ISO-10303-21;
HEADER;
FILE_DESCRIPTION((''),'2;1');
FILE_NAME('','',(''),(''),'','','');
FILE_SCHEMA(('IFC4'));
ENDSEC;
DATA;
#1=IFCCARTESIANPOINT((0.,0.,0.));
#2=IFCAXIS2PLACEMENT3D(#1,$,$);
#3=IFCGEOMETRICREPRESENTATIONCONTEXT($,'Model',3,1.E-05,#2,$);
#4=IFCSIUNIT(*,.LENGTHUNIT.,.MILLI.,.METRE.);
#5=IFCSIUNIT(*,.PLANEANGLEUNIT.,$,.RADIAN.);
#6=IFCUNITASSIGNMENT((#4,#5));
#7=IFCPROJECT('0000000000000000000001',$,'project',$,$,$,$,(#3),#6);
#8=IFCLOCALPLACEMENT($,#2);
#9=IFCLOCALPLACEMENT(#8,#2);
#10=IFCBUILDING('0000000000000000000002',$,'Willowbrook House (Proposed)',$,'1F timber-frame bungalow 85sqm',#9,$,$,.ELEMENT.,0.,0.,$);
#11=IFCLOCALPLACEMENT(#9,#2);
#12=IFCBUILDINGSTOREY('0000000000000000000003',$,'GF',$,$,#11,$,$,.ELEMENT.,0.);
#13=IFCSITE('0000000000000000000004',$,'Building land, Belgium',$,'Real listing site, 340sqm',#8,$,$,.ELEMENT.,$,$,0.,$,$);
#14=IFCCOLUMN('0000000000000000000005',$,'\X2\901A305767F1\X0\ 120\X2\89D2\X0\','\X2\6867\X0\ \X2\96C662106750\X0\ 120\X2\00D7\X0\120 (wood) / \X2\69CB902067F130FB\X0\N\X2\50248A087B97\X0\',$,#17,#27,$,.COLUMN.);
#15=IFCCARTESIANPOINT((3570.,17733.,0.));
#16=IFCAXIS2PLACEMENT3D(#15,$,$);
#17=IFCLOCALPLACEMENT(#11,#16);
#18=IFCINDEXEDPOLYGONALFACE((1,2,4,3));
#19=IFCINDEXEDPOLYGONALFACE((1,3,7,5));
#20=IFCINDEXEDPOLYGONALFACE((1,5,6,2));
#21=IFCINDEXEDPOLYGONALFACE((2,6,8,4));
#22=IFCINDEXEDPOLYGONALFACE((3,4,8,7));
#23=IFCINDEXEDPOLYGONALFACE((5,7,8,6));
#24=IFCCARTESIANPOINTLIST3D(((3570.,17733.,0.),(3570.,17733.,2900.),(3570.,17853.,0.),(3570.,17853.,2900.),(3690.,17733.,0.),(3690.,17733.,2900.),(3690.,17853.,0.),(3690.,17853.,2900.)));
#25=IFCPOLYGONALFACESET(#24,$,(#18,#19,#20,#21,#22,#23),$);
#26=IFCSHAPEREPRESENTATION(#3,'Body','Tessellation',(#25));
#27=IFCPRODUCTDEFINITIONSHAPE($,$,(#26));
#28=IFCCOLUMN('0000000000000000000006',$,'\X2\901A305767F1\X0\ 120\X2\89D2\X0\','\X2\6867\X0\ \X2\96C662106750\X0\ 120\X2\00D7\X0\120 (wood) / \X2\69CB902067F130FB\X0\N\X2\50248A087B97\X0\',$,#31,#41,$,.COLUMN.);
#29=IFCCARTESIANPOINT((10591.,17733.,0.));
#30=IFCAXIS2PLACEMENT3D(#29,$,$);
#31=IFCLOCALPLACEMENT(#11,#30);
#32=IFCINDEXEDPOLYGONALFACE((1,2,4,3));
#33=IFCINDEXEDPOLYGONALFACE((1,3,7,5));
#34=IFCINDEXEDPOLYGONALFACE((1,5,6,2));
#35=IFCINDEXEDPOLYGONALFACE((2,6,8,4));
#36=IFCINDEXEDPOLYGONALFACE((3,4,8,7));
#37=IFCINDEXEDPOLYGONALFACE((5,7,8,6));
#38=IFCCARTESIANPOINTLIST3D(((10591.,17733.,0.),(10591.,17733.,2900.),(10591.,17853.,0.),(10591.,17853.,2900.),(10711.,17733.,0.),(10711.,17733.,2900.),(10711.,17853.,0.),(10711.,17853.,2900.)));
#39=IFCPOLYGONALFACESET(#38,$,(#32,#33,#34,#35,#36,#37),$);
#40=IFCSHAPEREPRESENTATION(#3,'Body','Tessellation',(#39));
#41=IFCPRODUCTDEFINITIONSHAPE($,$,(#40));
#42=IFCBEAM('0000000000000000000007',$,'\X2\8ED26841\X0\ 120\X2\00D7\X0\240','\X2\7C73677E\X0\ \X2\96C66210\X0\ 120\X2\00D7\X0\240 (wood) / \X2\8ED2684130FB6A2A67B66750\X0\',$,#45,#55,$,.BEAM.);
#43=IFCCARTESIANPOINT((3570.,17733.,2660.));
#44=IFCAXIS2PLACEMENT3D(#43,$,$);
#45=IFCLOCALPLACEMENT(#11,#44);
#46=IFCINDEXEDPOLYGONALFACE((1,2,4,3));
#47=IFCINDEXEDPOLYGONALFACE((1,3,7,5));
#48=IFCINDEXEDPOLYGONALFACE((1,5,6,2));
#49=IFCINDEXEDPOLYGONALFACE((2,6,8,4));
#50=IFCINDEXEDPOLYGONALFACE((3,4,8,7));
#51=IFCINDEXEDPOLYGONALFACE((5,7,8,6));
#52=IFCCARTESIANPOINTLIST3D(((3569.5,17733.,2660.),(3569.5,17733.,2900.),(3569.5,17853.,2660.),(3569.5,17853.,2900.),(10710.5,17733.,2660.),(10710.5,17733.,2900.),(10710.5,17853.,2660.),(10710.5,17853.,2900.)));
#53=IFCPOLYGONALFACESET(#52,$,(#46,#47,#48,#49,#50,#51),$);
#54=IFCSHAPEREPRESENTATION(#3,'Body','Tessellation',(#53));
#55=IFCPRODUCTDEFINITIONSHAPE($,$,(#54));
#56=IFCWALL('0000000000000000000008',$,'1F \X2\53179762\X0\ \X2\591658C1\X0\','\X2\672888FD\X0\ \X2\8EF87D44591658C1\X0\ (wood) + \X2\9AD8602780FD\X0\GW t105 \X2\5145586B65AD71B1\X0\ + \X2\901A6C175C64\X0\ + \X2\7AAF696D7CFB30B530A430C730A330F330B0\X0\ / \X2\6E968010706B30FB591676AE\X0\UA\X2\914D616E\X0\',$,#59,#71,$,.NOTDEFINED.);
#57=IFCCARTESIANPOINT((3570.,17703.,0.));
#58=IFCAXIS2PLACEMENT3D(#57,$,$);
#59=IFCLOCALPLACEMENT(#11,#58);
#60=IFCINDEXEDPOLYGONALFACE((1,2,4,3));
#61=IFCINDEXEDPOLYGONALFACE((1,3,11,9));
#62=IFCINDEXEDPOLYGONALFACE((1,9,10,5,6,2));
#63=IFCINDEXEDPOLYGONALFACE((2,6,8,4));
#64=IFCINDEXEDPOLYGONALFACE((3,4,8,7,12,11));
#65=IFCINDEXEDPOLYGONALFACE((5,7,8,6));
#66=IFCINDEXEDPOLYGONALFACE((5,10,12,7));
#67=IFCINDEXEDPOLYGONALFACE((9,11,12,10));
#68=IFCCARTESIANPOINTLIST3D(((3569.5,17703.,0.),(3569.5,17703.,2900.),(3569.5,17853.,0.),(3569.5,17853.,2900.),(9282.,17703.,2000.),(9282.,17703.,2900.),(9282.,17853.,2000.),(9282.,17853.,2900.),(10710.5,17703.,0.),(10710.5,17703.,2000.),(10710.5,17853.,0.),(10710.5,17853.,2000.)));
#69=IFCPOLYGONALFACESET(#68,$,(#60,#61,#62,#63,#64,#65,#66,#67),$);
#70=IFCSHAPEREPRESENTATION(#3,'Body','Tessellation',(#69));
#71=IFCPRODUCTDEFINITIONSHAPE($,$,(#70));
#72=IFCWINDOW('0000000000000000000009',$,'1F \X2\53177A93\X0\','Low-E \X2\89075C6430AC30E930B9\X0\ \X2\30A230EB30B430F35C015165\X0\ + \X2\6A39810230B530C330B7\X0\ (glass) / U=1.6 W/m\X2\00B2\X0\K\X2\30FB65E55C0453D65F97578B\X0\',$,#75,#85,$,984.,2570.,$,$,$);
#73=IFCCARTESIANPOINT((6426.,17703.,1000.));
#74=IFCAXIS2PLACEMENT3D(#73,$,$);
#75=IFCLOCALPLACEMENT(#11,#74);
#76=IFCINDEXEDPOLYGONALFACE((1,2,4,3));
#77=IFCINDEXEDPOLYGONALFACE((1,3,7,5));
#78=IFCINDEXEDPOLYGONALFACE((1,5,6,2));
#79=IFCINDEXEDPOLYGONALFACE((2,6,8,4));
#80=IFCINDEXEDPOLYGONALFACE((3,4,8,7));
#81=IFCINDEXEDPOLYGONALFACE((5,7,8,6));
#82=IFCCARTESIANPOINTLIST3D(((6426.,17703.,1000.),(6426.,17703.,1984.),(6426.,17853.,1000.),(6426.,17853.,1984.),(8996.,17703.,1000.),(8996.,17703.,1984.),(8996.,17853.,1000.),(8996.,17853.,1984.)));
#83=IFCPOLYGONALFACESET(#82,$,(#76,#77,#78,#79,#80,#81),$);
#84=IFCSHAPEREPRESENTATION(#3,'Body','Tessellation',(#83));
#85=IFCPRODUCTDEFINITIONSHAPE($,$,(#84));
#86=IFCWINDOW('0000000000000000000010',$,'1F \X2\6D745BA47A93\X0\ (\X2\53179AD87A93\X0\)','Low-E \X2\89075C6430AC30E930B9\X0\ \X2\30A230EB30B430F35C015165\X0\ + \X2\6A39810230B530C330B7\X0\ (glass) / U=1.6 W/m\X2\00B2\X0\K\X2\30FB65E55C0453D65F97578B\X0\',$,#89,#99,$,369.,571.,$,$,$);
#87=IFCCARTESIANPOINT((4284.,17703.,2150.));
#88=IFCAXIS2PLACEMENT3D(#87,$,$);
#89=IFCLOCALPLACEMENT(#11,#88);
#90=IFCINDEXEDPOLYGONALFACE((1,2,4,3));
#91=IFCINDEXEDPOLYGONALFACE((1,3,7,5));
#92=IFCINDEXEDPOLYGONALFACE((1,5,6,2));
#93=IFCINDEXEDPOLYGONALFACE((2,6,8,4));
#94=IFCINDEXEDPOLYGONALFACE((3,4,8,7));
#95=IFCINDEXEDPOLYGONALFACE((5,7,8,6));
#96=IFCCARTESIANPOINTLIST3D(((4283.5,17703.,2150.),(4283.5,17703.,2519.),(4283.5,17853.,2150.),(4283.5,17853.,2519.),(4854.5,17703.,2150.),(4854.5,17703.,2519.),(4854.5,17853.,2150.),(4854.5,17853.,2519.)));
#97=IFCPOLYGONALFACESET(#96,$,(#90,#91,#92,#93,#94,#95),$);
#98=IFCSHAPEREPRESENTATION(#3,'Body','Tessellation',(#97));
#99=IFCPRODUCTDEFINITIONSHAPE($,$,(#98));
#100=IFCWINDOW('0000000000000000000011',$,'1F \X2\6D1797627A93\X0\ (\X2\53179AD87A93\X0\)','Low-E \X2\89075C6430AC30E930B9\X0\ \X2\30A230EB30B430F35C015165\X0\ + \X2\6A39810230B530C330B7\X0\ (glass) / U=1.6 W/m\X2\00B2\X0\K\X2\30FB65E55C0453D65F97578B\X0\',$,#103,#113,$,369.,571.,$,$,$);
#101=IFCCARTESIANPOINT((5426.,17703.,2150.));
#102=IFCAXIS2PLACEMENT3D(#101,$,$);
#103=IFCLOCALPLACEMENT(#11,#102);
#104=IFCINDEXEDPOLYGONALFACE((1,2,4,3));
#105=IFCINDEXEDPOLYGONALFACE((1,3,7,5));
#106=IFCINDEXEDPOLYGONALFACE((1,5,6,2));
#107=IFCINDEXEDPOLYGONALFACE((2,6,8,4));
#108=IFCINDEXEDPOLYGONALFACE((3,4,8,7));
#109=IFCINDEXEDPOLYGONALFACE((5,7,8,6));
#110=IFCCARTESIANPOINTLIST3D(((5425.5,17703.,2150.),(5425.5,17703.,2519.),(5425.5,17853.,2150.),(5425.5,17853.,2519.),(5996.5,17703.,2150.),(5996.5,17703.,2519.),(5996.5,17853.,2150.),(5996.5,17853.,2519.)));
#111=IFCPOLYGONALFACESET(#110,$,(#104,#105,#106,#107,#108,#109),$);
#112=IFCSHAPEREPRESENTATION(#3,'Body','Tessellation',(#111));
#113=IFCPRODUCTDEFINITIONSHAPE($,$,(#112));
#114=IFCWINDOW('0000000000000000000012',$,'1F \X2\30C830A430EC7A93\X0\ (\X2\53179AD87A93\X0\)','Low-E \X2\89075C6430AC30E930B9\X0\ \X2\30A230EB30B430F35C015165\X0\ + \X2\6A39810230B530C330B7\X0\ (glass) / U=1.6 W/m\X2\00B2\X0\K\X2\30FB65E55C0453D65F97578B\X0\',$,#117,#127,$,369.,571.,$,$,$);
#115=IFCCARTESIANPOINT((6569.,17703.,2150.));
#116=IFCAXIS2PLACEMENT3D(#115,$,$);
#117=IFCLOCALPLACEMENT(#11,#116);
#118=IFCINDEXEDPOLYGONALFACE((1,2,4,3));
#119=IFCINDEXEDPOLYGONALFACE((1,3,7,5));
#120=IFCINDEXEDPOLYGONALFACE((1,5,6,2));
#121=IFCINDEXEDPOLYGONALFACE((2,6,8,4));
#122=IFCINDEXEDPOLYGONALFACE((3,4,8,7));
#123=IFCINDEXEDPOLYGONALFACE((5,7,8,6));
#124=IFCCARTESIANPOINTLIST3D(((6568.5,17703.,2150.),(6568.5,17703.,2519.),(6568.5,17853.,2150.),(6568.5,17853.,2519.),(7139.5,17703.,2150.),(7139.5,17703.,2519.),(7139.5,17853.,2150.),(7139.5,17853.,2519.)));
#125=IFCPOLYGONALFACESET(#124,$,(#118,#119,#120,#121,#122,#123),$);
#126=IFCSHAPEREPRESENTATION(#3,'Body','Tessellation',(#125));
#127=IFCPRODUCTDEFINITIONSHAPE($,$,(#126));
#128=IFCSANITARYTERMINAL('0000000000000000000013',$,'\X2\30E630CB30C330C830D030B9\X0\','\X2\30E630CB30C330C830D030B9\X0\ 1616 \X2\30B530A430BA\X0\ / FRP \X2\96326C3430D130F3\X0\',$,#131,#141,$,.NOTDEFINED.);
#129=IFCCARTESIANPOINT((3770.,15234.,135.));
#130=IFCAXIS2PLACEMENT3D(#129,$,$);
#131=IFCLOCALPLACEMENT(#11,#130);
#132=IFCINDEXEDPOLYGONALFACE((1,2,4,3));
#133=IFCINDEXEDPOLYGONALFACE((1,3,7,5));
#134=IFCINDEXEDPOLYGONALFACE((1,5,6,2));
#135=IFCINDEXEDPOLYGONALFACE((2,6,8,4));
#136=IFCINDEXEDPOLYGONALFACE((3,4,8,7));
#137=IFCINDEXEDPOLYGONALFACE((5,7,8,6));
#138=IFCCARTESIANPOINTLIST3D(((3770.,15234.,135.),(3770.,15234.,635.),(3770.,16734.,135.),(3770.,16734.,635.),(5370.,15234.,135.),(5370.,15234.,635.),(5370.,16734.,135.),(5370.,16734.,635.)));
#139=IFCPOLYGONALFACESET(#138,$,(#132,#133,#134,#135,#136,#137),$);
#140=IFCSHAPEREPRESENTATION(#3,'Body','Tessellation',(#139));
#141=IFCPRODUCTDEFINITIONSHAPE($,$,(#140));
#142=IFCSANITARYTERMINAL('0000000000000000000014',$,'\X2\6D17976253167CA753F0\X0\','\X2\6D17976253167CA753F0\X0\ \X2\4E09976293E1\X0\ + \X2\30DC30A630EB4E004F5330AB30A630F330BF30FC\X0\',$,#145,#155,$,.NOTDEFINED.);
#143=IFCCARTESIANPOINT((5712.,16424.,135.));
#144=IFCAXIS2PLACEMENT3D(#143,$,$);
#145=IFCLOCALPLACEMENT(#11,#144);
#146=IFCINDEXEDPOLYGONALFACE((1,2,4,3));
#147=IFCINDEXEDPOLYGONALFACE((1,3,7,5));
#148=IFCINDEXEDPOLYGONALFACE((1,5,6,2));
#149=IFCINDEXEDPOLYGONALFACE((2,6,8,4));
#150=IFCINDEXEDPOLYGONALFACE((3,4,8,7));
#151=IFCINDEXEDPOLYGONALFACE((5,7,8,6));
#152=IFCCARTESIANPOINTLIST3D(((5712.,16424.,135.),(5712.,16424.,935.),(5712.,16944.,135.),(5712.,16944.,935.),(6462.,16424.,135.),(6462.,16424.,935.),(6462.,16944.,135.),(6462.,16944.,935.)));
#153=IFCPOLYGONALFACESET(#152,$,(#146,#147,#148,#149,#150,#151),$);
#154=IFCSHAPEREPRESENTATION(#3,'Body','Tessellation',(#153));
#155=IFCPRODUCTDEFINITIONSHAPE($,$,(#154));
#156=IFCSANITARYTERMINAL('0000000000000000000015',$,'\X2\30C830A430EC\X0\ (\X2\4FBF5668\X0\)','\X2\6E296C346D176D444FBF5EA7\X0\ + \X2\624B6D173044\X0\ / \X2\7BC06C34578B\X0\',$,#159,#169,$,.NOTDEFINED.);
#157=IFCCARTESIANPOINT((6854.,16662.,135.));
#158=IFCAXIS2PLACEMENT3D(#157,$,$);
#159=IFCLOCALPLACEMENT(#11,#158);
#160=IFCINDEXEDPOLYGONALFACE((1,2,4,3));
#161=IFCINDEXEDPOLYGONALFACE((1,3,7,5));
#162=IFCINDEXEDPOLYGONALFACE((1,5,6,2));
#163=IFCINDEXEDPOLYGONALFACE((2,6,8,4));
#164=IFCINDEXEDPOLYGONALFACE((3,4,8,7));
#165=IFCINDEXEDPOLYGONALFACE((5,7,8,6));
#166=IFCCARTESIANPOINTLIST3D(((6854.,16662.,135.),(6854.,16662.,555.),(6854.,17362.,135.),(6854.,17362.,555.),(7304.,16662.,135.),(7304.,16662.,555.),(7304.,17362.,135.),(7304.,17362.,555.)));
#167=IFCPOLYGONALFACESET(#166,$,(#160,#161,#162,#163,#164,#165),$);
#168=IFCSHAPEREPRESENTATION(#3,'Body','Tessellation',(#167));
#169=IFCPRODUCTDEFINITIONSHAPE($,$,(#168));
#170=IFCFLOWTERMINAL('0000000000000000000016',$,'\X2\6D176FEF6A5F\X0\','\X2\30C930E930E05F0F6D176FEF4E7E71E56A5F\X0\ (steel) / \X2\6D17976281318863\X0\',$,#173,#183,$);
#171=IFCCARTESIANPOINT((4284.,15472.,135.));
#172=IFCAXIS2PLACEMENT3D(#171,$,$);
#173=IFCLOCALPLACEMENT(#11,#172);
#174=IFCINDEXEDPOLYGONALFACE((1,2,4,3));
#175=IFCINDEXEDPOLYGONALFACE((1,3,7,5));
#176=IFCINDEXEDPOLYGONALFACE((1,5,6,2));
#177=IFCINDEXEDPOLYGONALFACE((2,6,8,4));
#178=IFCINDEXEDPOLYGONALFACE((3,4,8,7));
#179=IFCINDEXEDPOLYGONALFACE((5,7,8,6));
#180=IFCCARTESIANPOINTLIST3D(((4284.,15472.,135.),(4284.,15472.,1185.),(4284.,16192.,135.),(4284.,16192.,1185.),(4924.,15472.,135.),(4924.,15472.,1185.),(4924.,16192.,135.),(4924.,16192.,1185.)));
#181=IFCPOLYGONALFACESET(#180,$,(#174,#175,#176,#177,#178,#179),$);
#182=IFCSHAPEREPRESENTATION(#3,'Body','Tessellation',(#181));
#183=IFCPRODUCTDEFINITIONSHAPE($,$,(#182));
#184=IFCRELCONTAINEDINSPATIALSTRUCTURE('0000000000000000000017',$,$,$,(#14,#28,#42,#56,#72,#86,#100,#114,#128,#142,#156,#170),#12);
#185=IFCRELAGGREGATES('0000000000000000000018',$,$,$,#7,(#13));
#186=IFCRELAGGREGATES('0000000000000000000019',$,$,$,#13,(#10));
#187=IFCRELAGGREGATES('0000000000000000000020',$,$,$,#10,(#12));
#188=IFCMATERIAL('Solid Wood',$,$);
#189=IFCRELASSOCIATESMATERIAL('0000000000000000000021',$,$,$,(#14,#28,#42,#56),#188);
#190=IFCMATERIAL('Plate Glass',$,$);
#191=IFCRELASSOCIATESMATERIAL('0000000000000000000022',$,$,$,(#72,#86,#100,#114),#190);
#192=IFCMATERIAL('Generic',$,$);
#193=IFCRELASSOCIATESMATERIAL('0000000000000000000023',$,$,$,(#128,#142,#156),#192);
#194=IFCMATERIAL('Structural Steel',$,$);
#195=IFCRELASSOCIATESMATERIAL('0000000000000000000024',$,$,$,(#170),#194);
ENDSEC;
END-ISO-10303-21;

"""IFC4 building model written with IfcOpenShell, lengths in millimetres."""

from ifc_helpers import new_model, si_unit, frame, frame_2d, origin, place, context, project, spatial, rectangle, extrude, material, element, fill, save


model = new_model("IFC4")

# Units and contexts
model_context = context("Model", 3, precision=1e-05, world=origin())
ifc_project = project(units=[si_unit("LENGTHUNIT", "METRE", prefix="MILLI"), si_unit("PLANEANGLEUNIT", "RADIAN")], contexts=[model_context])

# Site, building, storey
site_placement = place(None, origin())
site = spatial("IfcSite", under=ifc_project, at=site_placement, Name="Building land, Belgium", ObjectType="Real listing site, 340sqm", CompositionType="ELEMENT", RefElevation=0.0)
building_placement = place(site_placement, origin())
building = spatial("IfcBuilding", under=site, at=building_placement, Name="Willowbrook House (Proposed)", ObjectType="1F timber-frame bungalow 85sqm", CompositionType="ELEMENT", ElevationOfRefHeight=0.0, ElevationOfTerrain=0.0)
storey_placement = place(building_placement, origin())
storey = spatial("IfcBuildingStorey", under=building, at=storey_placement, Name="GF", CompositionType="ELEMENT", Elevation=0.0)

# Columns
ifc_material_1 = material(Name="Solid Wood")
column_1_placement = place(storey_placement, frame((3570.0, 17733.0, 0.0)))
element("IfcColumn", 1, at=column_1_placement, inside=storey, material=ifc_material_1, Name="通し柱 120角", Description="桧 集成材 120×120 (wood) / 構造柱・N値計算", PredefinedType="COLUMN", context=model_context, shape_type="SweptSolid", body=[
    extrude(rectangle(XDim=120.0, YDim=120.0, at=frame_2d((60.0, 60.0))), frame((3570.0, 17733.0, 0.0)), (0.0, 0.0, 1.0), 2900.0),
])
column_2_placement = place(storey_placement, frame((10591.0, 17733.0, 0.0)))
element("IfcColumn", 2, at=column_2_placement, inside=storey, material=ifc_material_1, Name="通し柱 120角", Description="桧 集成材 120×120 (wood) / 構造柱・N値計算", PredefinedType="COLUMN", context=model_context, shape_type="SweptSolid", body=[
    extrude(rectangle(XDim=120.0, YDim=120.0, at=frame_2d((60.0, 60.0))), frame((10591.0, 17733.0, 0.0)), (0.0, 0.0, 1.0), 2900.0),
])

# Beam
beam_1_placement = place(storey_placement, frame((3570.0, 17733.0, 2660.0)))
element("IfcBeam", 3, at=beam_1_placement, inside=storey, material=ifc_material_1, Name="軒桁 120×240", Description="米松 集成 120×240 (wood) / 軒桁・横架材", PredefinedType="BEAM", context=model_context, shape_type="SweptSolid", body=[
    extrude(rectangle(XDim=7141.0, YDim=120.0, at=frame_2d((3570.0, 60.0))), frame((3570.0, 17733.0, 2660.0)), (0.0, 0.0, 1.0), 240.0),
])

# Wall, openings, windows
wall_placement = place(storey_placement, frame((3570.0, 17703.0, 0.0)))
wall = element("IfcWall", 4, at=wall_placement, inside=storey, material=ifc_material_1, Name="1F 北面 外壁", Description="木製 軸組外壁 (wood) + 高性能GW t105 充填断熱 + 通気層 + 窯業系サイディング / 準耐火・外皮UA配慮", PredefinedType="NOTDEFINED", context=model_context, shape_type="SweptSolid", body=[
    extrude(rectangle(XDim=7141.0, YDim=150.0, at=frame_2d((3570.0, 75.0))), frame((3570.0, 17703.0, 0.0)), (0.0, 0.0, 1.0), 2900.0),
])
opening_1_placement = place(storey_placement, frame((6426.0, 17703.0, 1000.0)))
opening_1 = element("IfcOpeningElement", 5, at=opening_1_placement, cuts=wall, PredefinedType="NOTDEFINED", context=model_context, shape_type="SweptSolid", body=[
    extrude(rectangle(XDim=2570.0, YDim=150.0, at=frame_2d((1285.0, 75.0))), frame((6426.0, 17703.0, 1000.0)), (0.0, 0.0, 1.0), 984.0),
])
opening_2_placement = place(storey_placement, frame((4284.0, 17703.0, 2150.0)))
opening_2 = element("IfcOpeningElement", 6, at=opening_2_placement, cuts=wall, PredefinedType="NOTDEFINED", context=model_context, shape_type="SweptSolid", body=[
    extrude(rectangle(XDim=571.0, YDim=150.0, at=frame_2d((285.0, 75.0))), frame((4284.0, 17703.0, 2150.0)), (0.0, 0.0, 1.0), 369.0),
])
opening_3_placement = place(storey_placement, frame((5426.0, 17703.0, 2150.0)))
opening_3 = element("IfcOpeningElement", 7, at=opening_3_placement, cuts=wall, PredefinedType="NOTDEFINED", context=model_context, shape_type="SweptSolid", body=[
    extrude(rectangle(XDim=571.0, YDim=150.0, at=frame_2d((285.0, 75.0))), frame((5426.0, 17703.0, 2150.0)), (0.0, 0.0, 1.0), 369.0),
])
opening_4_placement = place(storey_placement, frame((6569.0, 17703.0, 2150.0)))
opening_4 = element("IfcOpeningElement", 8, at=opening_4_placement, cuts=wall, PredefinedType="NOTDEFINED", context=model_context, shape_type="SweptSolid", body=[
    extrude(rectangle(XDim=571.0, YDim=150.0, at=frame_2d((285.0, 75.0))), frame((6569.0, 17703.0, 2150.0)), (0.0, 0.0, 1.0), 369.0),
])
ifc_material_2 = material(Name="Plate Glass")
window_1_placement = place(storey_placement, frame((6426.0, 17703.0, 1000.0)))
window_1 = element("IfcWindow", 9, at=window_1_placement, inside=storey, material=ifc_material_2, Name="1F 北窓", Description="Low-E 複層ガラス アルゴン封入 + 樹脂サッシ (glass) / U=1.6 W/m²K・日射取得型", OverallHeight=984.0, OverallWidth=2570.0, context=model_context, shape_type="SweptSolid", body=[
    extrude(rectangle(XDim=2570.0, YDim=150.0, at=frame_2d((1285.0, 75.0))), frame((6426.0, 17703.0, 1000.0)), (0.0, 0.0, 1.0), 984.0),
])
fill(opening_1, window_1)
window_2_placement = place(storey_placement, frame((4284.0, 17703.0, 2150.0)))
window_2 = element("IfcWindow", 10, at=window_2_placement, inside=storey, material=ifc_material_2, Name="1F 浴室窓 (北高窓)", Description="Low-E 複層ガラス アルゴン封入 + 樹脂サッシ (glass) / U=1.6 W/m²K・日射取得型", OverallHeight=369.0, OverallWidth=571.0, context=model_context, shape_type="SweptSolid", body=[
    extrude(rectangle(XDim=571.0, YDim=150.0, at=frame_2d((285.0, 75.0))), frame((4284.0, 17703.0, 2150.0)), (0.0, 0.0, 1.0), 369.0),
])
fill(opening_2, window_2)
window_3_placement = place(storey_placement, frame((5426.0, 17703.0, 2150.0)))
window_3 = element("IfcWindow", 11, at=window_3_placement, inside=storey, material=ifc_material_2, Name="1F 洗面窓 (北高窓)", Description="Low-E 複層ガラス アルゴン封入 + 樹脂サッシ (glass) / U=1.6 W/m²K・日射取得型", OverallHeight=369.0, OverallWidth=571.0, context=model_context, shape_type="SweptSolid", body=[
    extrude(rectangle(XDim=571.0, YDim=150.0, at=frame_2d((285.0, 75.0))), frame((5426.0, 17703.0, 2150.0)), (0.0, 0.0, 1.0), 369.0),
])
fill(opening_3, window_3)
window_4_placement = place(storey_placement, frame((6569.0, 17703.0, 2150.0)))
window_4 = element("IfcWindow", 12, at=window_4_placement, inside=storey, material=ifc_material_2, Name="1F トイレ窓 (北高窓)", Description="Low-E 複層ガラス アルゴン封入 + 樹脂サッシ (glass) / U=1.6 W/m²K・日射取得型", OverallHeight=369.0, OverallWidth=571.0, context=model_context, shape_type="SweptSolid", body=[
    extrude(rectangle(XDim=571.0, YDim=150.0, at=frame_2d((285.0, 75.0))), frame((6569.0, 17703.0, 2150.0)), (0.0, 0.0, 1.0), 369.0),
])
fill(opening_4, window_4)

# Sanitary terminals
ifc_material_3 = material(Name="Generic")
sanitary_terminal_1_placement = place(storey_placement, frame((3770.0, 15234.0, 135.0)))
element("IfcSanitaryTerminal", 13, at=sanitary_terminal_1_placement, inside=storey, material=ifc_material_3, Name="ユニットバス", Description="ユニットバス 1616 サイズ / FRP 防水パン", PredefinedType="NOTDEFINED", context=model_context, shape_type="SweptSolid", body=[
    extrude(rectangle(XDim=1600.0, YDim=1500.0, at=frame_2d((800.0, 750.0))), frame((3770.0, 15234.0, 135.0)), (0.0, 0.0, 1.0), 500.0),
])
sanitary_terminal_2_placement = place(storey_placement, frame((5712.0, 16424.0, 135.0)))
element("IfcSanitaryTerminal", 14, at=sanitary_terminal_2_placement, inside=storey, material=ifc_material_3, Name="洗面化粧台", Description="洗面化粧台 三面鏡 + ボウル一体カウンター", PredefinedType="NOTDEFINED", context=model_context, shape_type="SweptSolid", body=[
    extrude(rectangle(XDim=750.0, YDim=520.0, at=frame_2d((375.0, 260.0))), frame((5712.0, 16424.0, 135.0)), (0.0, 0.0, 1.0), 800.0),
])
sanitary_terminal_3_placement = place(storey_placement, frame((6854.0, 16662.0, 135.0)))
element("IfcSanitaryTerminal", 15, at=sanitary_terminal_3_placement, inside=storey, material=ifc_material_3, Name="トイレ (便器)", Description="温水洗浄便座 + 手洗い / 節水型", PredefinedType="NOTDEFINED", context=model_context, shape_type="SweptSolid", body=[
    extrude(rectangle(XDim=450.0, YDim=700.0, at=frame_2d((225.0, 350.0))), frame((6854.0, 16662.0, 135.0)), (0.0, 0.0, 1.0), 420.0),
])

# Flow terminal
ifc_material_4 = material(Name="Structural Steel")
flow_terminal_placement = place(storey_placement, frame((4284.0, 15472.0, 135.0)))
element("IfcFlowTerminal", 16, at=flow_terminal_placement, inside=storey, material=ifc_material_4, Name="洗濯機", Description="ドラム式洗濯乾燥機 (steel) / 洗面脱衣", context=model_context, shape_type="SweptSolid", body=[
    extrude(rectangle(XDim=640.0, YDim=720.0, at=frame_2d((320.0, 360.0))), frame((4284.0, 15472.0, 135.0)), (0.0, 0.0, 1.0), 1050.0),
])

save(model, "model.ifc")
